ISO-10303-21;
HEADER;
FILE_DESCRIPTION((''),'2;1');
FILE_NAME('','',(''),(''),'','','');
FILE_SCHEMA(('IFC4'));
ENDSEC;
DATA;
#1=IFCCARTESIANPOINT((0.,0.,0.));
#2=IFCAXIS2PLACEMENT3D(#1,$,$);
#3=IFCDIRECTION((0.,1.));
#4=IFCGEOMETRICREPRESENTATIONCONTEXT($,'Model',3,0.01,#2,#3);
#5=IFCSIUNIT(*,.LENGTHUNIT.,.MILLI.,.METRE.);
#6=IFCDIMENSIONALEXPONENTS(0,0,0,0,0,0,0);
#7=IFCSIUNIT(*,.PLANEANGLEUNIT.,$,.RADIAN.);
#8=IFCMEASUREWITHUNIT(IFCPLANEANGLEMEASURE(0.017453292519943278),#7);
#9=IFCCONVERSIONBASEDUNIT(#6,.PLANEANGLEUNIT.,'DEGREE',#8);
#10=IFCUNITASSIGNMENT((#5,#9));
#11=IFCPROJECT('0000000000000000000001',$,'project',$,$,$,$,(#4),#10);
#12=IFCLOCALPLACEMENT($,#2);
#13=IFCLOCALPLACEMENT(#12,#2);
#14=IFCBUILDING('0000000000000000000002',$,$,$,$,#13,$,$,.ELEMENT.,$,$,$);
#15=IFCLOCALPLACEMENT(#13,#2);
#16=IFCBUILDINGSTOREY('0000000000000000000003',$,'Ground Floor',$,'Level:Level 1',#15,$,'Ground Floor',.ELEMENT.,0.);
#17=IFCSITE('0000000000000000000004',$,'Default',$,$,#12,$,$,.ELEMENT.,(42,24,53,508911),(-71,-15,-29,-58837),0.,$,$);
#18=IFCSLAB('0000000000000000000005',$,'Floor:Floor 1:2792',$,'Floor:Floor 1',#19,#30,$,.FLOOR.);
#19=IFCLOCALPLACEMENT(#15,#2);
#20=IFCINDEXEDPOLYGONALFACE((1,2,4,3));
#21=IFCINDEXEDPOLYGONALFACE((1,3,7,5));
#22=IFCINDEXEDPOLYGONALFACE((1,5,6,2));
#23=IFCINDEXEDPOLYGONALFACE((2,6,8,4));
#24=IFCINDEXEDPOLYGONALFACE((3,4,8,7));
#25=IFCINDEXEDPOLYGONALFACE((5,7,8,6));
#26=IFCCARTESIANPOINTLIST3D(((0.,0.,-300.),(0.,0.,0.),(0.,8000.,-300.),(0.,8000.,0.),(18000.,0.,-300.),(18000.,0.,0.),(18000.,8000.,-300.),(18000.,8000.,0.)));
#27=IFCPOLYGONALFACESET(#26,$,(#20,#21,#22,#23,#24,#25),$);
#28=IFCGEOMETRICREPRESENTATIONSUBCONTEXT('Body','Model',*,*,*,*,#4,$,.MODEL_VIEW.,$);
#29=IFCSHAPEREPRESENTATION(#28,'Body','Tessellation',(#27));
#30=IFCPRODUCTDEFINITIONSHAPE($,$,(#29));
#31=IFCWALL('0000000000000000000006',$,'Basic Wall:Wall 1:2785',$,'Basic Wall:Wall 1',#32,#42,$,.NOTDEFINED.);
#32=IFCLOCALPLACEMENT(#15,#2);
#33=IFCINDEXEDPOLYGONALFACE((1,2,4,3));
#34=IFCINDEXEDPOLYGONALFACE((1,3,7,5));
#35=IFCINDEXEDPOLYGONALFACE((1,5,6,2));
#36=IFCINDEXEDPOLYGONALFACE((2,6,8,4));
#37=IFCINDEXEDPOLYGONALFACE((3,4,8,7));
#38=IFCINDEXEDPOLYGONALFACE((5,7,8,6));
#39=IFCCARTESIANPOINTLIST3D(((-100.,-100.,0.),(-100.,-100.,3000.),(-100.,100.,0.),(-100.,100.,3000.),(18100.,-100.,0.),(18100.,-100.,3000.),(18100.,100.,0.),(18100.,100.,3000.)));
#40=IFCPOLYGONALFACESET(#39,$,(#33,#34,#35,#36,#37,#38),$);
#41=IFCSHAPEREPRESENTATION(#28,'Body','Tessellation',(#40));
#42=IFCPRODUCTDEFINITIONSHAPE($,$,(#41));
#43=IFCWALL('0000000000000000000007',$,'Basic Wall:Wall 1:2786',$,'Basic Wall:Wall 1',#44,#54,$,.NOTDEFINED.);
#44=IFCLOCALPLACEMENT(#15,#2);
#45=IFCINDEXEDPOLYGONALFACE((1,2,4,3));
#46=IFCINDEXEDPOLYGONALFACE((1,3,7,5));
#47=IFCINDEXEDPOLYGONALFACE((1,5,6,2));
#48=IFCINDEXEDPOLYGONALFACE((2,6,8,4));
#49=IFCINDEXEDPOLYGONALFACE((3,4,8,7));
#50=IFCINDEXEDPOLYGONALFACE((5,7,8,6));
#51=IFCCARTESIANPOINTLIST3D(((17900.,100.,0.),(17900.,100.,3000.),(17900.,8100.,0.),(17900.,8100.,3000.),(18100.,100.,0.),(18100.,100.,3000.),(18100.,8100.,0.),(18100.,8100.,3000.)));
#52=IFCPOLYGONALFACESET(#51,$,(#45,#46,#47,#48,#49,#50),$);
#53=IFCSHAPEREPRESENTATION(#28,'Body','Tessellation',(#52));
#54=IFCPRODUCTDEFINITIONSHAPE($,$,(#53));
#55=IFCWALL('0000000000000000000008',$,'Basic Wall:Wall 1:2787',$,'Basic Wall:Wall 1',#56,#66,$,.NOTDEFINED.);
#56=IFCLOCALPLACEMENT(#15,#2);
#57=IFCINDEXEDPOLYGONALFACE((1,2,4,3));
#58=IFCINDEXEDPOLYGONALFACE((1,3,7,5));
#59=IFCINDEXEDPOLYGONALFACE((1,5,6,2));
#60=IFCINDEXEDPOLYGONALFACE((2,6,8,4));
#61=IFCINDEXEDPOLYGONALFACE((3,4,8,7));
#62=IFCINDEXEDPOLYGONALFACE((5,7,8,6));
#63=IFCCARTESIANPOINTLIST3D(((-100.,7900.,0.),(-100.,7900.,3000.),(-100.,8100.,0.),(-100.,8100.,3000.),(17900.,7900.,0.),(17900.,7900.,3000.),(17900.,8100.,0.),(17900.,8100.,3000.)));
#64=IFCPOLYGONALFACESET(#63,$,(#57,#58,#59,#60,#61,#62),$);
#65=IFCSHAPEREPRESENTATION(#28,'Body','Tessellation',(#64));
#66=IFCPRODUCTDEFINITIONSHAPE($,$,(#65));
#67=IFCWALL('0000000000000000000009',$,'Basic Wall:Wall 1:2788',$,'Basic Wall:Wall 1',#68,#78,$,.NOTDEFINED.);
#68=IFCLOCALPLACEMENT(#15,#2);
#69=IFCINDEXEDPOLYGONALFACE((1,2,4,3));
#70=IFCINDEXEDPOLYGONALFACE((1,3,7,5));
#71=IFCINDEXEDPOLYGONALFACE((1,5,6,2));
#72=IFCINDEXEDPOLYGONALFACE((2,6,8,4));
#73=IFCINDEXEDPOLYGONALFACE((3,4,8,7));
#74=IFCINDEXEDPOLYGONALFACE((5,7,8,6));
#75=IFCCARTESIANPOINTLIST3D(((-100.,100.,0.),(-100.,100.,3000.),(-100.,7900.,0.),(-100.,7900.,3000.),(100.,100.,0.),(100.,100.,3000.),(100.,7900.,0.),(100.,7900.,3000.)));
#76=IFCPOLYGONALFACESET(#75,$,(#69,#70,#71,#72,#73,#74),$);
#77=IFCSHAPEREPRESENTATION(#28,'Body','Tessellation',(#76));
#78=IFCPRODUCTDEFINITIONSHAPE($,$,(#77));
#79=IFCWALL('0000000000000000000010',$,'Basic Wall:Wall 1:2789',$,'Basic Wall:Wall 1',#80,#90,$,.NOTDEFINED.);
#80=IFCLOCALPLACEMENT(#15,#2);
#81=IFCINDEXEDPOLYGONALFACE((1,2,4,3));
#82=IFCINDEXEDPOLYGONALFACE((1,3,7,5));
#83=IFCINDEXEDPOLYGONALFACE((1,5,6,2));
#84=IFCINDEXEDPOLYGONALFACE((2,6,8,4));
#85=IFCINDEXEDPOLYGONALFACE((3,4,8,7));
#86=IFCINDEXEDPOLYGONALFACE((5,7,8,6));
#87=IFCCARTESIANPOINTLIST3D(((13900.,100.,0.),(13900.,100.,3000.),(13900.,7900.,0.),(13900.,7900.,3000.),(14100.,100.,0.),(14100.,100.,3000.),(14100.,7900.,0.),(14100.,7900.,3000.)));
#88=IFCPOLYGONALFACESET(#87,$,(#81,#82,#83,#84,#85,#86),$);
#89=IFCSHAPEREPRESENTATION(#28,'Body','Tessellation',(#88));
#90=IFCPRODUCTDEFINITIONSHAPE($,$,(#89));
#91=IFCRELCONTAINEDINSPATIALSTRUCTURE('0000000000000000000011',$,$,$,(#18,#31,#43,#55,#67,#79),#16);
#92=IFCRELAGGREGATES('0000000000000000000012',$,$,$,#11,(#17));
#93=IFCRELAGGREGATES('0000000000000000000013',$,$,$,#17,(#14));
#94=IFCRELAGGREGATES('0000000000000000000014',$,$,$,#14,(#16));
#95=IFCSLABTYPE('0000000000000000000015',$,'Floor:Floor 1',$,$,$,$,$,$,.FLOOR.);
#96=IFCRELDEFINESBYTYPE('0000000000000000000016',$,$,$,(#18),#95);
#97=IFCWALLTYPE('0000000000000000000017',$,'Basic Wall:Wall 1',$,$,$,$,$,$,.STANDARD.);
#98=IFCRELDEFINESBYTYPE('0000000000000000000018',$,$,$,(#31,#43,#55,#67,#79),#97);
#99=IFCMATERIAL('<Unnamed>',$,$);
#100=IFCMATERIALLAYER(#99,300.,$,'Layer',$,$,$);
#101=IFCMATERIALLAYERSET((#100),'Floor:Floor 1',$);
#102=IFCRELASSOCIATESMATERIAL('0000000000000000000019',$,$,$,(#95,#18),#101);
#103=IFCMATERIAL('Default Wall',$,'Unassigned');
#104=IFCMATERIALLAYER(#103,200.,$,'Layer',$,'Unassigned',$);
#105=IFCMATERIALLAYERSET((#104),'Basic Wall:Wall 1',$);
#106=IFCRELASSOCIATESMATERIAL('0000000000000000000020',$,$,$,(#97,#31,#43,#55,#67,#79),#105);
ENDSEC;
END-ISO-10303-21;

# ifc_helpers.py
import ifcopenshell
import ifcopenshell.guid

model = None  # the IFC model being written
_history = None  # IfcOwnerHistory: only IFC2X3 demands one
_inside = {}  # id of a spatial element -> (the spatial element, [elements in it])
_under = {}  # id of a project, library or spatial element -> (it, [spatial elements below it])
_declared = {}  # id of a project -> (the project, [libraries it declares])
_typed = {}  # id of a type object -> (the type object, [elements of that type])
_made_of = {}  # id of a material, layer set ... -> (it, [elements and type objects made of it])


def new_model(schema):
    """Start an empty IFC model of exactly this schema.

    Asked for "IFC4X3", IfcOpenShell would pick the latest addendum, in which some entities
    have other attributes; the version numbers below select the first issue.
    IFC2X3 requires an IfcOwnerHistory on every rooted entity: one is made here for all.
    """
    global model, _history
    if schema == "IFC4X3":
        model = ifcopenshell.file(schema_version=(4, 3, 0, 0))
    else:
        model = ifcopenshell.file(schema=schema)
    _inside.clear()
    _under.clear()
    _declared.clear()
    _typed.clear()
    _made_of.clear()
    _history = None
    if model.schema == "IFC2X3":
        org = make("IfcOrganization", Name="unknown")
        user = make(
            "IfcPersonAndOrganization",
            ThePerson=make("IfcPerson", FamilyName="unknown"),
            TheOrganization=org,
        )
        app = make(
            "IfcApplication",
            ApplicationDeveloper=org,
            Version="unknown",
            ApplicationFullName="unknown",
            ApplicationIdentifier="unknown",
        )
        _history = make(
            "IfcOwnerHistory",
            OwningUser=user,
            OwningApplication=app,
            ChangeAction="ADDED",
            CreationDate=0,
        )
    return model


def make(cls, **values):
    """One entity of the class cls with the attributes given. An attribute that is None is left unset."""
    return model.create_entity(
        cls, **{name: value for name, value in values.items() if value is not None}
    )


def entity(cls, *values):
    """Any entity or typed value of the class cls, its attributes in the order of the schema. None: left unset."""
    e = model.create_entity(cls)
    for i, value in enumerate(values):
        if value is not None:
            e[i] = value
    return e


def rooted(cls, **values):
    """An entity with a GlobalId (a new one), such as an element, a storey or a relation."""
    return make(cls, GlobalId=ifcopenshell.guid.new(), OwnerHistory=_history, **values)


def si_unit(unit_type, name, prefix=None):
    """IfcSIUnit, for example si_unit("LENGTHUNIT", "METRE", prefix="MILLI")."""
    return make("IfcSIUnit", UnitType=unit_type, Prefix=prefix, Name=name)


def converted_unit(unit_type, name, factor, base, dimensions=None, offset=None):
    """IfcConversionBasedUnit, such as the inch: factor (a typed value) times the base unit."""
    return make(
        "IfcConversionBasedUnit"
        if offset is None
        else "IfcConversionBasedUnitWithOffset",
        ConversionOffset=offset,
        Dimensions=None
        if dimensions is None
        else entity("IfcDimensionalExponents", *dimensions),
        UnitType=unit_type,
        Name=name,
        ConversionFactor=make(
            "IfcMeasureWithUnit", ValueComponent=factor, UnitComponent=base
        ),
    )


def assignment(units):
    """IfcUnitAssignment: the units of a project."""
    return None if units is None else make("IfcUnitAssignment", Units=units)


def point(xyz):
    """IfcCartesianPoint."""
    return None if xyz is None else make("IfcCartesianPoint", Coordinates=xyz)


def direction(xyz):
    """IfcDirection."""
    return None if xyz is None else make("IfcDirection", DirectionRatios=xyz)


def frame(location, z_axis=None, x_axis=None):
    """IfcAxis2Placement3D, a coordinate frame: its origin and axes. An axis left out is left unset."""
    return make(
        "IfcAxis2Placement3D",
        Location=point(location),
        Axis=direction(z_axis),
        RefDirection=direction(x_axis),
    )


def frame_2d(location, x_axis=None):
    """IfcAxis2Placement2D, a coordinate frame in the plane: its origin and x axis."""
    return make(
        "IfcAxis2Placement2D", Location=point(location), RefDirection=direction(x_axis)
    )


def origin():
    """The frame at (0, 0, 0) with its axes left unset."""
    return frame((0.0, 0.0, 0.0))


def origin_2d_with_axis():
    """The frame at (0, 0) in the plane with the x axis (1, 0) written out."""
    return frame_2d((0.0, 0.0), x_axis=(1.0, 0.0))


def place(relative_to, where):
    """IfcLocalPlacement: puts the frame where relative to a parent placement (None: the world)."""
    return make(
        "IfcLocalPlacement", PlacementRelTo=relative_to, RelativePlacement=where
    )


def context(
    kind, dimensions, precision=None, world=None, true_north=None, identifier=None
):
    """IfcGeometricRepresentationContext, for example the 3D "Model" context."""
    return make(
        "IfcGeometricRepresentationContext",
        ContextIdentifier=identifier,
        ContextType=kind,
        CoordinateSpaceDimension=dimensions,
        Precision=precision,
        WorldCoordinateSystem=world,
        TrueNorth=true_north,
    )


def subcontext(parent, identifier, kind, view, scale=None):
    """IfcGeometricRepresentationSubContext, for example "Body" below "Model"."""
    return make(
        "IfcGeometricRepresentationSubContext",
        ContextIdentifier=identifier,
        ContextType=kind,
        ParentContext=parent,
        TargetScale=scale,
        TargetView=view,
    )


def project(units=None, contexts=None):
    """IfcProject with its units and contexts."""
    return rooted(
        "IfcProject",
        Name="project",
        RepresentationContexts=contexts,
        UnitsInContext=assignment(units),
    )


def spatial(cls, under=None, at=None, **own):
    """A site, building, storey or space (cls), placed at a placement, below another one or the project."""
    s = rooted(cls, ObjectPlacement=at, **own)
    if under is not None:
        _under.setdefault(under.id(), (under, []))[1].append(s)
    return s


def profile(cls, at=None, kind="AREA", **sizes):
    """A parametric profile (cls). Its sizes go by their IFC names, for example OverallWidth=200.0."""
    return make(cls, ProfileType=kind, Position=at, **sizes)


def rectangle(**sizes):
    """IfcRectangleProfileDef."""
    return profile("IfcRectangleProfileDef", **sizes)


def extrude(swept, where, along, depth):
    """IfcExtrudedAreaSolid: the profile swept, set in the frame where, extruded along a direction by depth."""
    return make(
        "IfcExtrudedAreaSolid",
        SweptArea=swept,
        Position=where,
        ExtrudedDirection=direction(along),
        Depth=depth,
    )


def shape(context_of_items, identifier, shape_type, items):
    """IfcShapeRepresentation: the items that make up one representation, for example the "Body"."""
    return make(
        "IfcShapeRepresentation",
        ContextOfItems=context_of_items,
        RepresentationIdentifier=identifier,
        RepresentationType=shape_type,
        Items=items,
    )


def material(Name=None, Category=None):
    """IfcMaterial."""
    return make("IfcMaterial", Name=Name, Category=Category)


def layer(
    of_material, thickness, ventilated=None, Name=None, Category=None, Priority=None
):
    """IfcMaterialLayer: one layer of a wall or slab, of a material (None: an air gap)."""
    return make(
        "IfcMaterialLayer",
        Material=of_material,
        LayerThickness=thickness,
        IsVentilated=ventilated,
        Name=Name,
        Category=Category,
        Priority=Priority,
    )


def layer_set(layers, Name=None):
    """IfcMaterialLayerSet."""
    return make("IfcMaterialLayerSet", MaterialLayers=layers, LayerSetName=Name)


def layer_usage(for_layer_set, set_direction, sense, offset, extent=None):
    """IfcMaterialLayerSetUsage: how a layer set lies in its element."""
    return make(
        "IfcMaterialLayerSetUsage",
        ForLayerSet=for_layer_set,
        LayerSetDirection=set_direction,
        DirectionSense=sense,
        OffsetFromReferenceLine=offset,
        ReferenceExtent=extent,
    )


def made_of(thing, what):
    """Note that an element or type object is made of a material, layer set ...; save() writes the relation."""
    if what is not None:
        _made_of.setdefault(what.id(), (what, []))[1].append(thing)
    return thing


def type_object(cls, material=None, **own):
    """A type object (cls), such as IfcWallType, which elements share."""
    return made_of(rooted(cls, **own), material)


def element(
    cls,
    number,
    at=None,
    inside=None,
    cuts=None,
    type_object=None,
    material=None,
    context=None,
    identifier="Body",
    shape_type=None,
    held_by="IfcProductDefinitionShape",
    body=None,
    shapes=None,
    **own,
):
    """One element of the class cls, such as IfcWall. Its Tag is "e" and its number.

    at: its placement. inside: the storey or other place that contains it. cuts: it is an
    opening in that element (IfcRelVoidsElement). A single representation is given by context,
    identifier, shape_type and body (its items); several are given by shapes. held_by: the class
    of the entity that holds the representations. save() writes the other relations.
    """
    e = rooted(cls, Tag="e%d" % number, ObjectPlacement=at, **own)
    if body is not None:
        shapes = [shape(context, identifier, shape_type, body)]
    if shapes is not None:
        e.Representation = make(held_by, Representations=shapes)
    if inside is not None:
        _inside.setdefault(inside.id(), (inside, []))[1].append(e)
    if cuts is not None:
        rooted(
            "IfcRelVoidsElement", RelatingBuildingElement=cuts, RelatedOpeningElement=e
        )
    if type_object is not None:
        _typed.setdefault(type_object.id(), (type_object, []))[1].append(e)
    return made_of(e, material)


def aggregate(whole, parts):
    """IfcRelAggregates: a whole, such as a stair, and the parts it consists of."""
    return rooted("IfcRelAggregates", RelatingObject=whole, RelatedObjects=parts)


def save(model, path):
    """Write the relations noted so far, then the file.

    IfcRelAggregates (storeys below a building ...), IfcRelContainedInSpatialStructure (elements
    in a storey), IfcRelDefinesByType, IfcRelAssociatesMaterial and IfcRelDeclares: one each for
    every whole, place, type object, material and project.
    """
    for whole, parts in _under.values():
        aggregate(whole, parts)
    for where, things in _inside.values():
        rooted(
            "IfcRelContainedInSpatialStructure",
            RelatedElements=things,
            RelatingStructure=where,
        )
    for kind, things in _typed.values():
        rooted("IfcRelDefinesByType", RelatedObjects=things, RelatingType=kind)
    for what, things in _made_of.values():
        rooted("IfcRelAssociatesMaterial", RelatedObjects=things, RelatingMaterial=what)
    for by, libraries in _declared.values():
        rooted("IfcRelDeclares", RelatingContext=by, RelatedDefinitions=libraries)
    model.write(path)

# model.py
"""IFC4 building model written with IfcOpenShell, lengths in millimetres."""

from ifc_helpers import new_model, entity, si_unit, converted_unit, direction, frame, frame_2d, origin, origin_2d_with_axis, place, context, subcontext, project, spatial, rectangle, extrude, material, layer, layer_set, layer_usage, type_object, element, save


model = new_model("IFC4")

# Units and contexts
model_context = context("Model", 3, precision=0.01, world=origin(), true_north=direction((0.0, 1.0)))
body_context = subcontext(model_context, "Body", "Model", "MODEL_VIEW")
ifc_project = project(units=[si_unit("LENGTHUNIT", "METRE", prefix="MILLI"), converted_unit("PLANEANGLEUNIT", "DEGREE", entity("IfcPlaneAngleMeasure", 0.017453292519943278), si_unit("PLANEANGLEUNIT", "RADIAN"), dimensions=[0, 0, 0, 0, 0, 0, 0])], contexts=[model_context])

# Site, building, storey
site_placement = place(None, origin())
site = spatial("IfcSite", under=ifc_project, at=site_placement, Name="Default", CompositionType="ELEMENT", RefLatitude=(42, 24, 53, 508911), RefLongitude=(-71, -15, -29, -58837), RefElevation=0.0)
building_placement = place(site_placement, origin())
building = spatial("IfcBuilding", under=site, at=building_placement, CompositionType="ELEMENT")
storey_placement = place(building_placement, origin())
storey = spatial("IfcBuildingStorey", under=building, at=storey_placement, Name="Ground Floor", ObjectType="Level:Level 1", LongName="Ground Floor", CompositionType="ELEMENT", Elevation=0.0)

# Slab
ifc_material_1 = material(Name="<Unnamed>")
ifc_layer_1 = layer(ifc_material_1, 300.0, Name="Layer")
ifc_layer_set_1 = layer_set([ifc_layer_1], Name="Floor:Floor 1")
ifc_layer_usage_1 = layer_usage(ifc_layer_set_1, "AXIS3", "POSITIVE", 0.0)
slab_type = type_object("IfcSlabType", Name="Floor:Floor 1", PredefinedType="FLOOR", material=ifc_layer_set_1)
slab_placement = place(storey_placement, origin())
element("IfcSlab", 1, at=slab_placement, inside=storey, type_object=slab_type, material=ifc_layer_usage_1, Name="Floor:Floor 1:2792", ObjectType="Floor:Floor 1", PredefinedType="FLOOR", context=body_context, shape_type="SweptSolid", body=[
    extrude(rectangle(XDim=8000.0, YDim=18000.0, at=origin_2d_with_axis()), frame((9000.0, 4000.0, 0.0), z_axis=(0.0, 0.0, -1.0), x_axis=(0.0, 1.0, 0.0)), (0.0, 0.0, 1.0), 300.0),
])

# Walls
ifc_material_2 = material(Name="Default Wall", Category="Unassigned")
ifc_layer_2 = layer(ifc_material_2, 200.0, Name="Layer", Category="Unassigned")
ifc_layer_set_2 = layer_set([ifc_layer_2], Name="Basic Wall:Wall 1")
ifc_layer_usage_2 = layer_usage(ifc_layer_set_2, "AXIS2", "NEGATIVE", 100.0)
wall_type = type_object("IfcWallType", Name="Basic Wall:Wall 1", PredefinedType="STANDARD", material=ifc_layer_set_2)
wall_1_placement = place(storey_placement, frame((-100.0, 0.0, 0.0)))
element("IfcWall", 2, at=wall_1_placement, inside=storey, type_object=wall_type, material=ifc_layer_usage_2, Name="Basic Wall:Wall 1:2785", ObjectType="Basic Wall:Wall 1", PredefinedType="NOTDEFINED", context=body_context, shape_type="SweptSolid", body=[
    extrude(rectangle(XDim=18200.0, YDim=200.0, at=frame_2d((9100.0, 0.0), x_axis=(-1.0, 0.0))), origin(), (0.0, 0.0, 1.0), 3000.0),
])
ifc_layer_usage_3 = layer_usage(ifc_layer_set_2, "AXIS2", "NEGATIVE", 100.0)
wall_2_placement = place(storey_placement, frame((18000.0, 100.0, 0.0), z_axis=(0.0, 0.0, 1.0), x_axis=(0.0, 1.0, 0.0)))
element("IfcWall", 3, at=wall_2_placement, inside=storey, type_object=wall_type, material=ifc_layer_usage_3, Name="Basic Wall:Wall 1:2786", ObjectType="Basic Wall:Wall 1", PredefinedType="NOTDEFINED", context=body_context, shape_type="SweptSolid", body=[
    extrude(rectangle(XDim=8000.0, YDim=200.0, at=frame_2d((4000.0, 0.0), x_axis=(-1.0, 0.0))), origin(), (0.0, 0.0, 1.0), 3000.0),
])
ifc_layer_usage_4 = layer_usage(ifc_layer_set_2, "AXIS2", "NEGATIVE", 100.0)
wall_3_placement = place(storey_placement, frame((17900.0, 8000.0, 0.0), z_axis=(0.0, 0.0, 1.0), x_axis=(-1.0, 0.0, 0.0)))
element("IfcWall", 4, at=wall_3_placement, inside=storey, type_object=wall_type, material=ifc_layer_usage_4, Name="Basic Wall:Wall 1:2787", ObjectType="Basic Wall:Wall 1", PredefinedType="NOTDEFINED", context=body_context, shape_type="SweptSolid", body=[
    extrude(rectangle(XDim=18000.0, YDim=200.0, at=frame_2d((9000.0, 0.0), x_axis=(-1.0, 0.0))), origin(), (0.0, 0.0, 1.0), 3000.0),
])
ifc_layer_usage_5 = layer_usage(ifc_layer_set_2, "AXIS2", "NEGATIVE", 100.0)
wall_4_placement = place(storey_placement, frame((0.0, 7900.0, 0.0), z_axis=(0.0, 0.0, 1.0), x_axis=(0.0, -1.0, 0.0)))
element("IfcWall", 5, at=wall_4_placement, inside=storey, type_object=wall_type, material=ifc_layer_usage_5, Name="Basic Wall:Wall 1:2788", ObjectType="Basic Wall:Wall 1", PredefinedType="NOTDEFINED", context=body_context, shape_type="SweptSolid", body=[
    extrude(rectangle(XDim=7800.0, YDim=200.0, at=frame_2d((3900.0, 0.0), x_axis=(-1.0, 0.0))), origin(), (0.0, 0.0, 1.0), 3000.0),
])
ifc_layer_usage_6 = layer_usage(ifc_layer_set_2, "AXIS2", "NEGATIVE", 100.0)
wall_5_placement = place(storey_placement, frame((14000.0, 100.0, 0.0), z_axis=(0.0, 0.0, 1.0), x_axis=(0.0, 1.0, 0.0)))
element("IfcWall", 6, at=wall_5_placement, inside=storey, type_object=wall_type, material=ifc_layer_usage_6, Name="Basic Wall:Wall 1:2789", ObjectType="Basic Wall:Wall 1", PredefinedType="NOTDEFINED", context=body_context, shape_type="SweptSolid", body=[
    extrude(rectangle(XDim=7800.0, YDim=200.0, at=frame_2d((3900.0, 0.0), x_axis=(-1.0, 0.0))), origin(), (0.0, 0.0, 1.0), 3000.0),
])

save(model, "model.ifc")
